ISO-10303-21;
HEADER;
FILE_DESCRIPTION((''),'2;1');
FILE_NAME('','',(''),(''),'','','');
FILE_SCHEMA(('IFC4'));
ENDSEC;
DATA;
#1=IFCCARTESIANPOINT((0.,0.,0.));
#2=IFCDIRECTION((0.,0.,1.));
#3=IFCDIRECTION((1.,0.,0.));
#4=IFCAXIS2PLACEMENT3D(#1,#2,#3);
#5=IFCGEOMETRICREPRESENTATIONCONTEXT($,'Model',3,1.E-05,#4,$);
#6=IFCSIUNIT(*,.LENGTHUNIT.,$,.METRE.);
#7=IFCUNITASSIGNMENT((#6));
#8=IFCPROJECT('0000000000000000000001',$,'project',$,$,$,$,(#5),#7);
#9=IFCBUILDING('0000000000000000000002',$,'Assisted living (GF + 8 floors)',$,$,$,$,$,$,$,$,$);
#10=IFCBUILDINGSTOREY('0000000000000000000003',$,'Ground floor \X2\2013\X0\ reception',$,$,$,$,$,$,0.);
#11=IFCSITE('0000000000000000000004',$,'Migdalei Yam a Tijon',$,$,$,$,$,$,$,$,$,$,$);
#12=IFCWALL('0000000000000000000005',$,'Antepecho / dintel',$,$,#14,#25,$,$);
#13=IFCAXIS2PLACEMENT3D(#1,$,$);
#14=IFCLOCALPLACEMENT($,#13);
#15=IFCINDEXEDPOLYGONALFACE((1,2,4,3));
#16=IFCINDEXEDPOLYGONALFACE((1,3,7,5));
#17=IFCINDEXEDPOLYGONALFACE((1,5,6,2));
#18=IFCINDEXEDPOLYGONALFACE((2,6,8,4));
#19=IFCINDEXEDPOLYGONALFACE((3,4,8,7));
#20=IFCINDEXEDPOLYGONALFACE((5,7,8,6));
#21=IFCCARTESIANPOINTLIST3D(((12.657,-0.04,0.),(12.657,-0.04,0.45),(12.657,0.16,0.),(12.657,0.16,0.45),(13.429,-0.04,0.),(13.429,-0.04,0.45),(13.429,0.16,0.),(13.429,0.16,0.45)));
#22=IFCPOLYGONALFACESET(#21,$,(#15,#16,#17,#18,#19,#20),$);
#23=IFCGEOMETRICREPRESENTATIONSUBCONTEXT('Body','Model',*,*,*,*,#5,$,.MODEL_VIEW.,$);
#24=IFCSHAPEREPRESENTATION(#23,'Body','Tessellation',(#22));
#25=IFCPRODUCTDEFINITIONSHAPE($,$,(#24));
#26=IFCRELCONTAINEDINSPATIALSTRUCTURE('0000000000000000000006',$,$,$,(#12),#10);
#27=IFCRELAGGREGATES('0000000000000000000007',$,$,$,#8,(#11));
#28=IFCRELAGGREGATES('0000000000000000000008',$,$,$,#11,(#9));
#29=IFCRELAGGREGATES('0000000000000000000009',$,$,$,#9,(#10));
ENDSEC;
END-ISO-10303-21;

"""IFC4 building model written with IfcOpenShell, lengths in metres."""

from ifc_helpers import new_model, si_unit, frame, origin_with_axes, context, subcontext, project, spatial, line, indexed_curve, outline, extrude, element, save


model = new_model("IFC4")

# Units and contexts
model_context = context("Model", 3, precision=1e-05, world=origin_with_axes())
body_context = subcontext(model_context, "Body", "Model", "MODEL_VIEW")
ifc_project = project(units=[si_unit("LENGTHUNIT", "METRE")], contexts=[model_context])

# Site, building, storey
site = spatial("IfcSite", under=ifc_project, Name="Migdalei Yam a Tijon")
building = spatial("IfcBuilding", under=site, Name="Assisted living (GF + 8 floors)")
storey = spatial("IfcBuildingStorey", under=building, Name="Ground floor – reception", Elevation=0.0)

# Wall
element("IfcWall", 1, inside=storey, Name="Antepecho / dintel", context=body_context, shape_type="SweptSolid", body=[
    extrude(outline(indexed_curve([(0.0, 0.0), (0.772, 0.0), (0.772, 0.2), (0.0, 0.2)], segments=[line(1, 2, 3, 4, 1)])), frame((12.657, -0.04, 0.0), z_axis=(0.0, 0.0, 1.0), x_axis=(1.0, 0.0, 0.0)), (0.0, 0.0, 1.0), 0.45),
])

save(model, "model.ifc")
